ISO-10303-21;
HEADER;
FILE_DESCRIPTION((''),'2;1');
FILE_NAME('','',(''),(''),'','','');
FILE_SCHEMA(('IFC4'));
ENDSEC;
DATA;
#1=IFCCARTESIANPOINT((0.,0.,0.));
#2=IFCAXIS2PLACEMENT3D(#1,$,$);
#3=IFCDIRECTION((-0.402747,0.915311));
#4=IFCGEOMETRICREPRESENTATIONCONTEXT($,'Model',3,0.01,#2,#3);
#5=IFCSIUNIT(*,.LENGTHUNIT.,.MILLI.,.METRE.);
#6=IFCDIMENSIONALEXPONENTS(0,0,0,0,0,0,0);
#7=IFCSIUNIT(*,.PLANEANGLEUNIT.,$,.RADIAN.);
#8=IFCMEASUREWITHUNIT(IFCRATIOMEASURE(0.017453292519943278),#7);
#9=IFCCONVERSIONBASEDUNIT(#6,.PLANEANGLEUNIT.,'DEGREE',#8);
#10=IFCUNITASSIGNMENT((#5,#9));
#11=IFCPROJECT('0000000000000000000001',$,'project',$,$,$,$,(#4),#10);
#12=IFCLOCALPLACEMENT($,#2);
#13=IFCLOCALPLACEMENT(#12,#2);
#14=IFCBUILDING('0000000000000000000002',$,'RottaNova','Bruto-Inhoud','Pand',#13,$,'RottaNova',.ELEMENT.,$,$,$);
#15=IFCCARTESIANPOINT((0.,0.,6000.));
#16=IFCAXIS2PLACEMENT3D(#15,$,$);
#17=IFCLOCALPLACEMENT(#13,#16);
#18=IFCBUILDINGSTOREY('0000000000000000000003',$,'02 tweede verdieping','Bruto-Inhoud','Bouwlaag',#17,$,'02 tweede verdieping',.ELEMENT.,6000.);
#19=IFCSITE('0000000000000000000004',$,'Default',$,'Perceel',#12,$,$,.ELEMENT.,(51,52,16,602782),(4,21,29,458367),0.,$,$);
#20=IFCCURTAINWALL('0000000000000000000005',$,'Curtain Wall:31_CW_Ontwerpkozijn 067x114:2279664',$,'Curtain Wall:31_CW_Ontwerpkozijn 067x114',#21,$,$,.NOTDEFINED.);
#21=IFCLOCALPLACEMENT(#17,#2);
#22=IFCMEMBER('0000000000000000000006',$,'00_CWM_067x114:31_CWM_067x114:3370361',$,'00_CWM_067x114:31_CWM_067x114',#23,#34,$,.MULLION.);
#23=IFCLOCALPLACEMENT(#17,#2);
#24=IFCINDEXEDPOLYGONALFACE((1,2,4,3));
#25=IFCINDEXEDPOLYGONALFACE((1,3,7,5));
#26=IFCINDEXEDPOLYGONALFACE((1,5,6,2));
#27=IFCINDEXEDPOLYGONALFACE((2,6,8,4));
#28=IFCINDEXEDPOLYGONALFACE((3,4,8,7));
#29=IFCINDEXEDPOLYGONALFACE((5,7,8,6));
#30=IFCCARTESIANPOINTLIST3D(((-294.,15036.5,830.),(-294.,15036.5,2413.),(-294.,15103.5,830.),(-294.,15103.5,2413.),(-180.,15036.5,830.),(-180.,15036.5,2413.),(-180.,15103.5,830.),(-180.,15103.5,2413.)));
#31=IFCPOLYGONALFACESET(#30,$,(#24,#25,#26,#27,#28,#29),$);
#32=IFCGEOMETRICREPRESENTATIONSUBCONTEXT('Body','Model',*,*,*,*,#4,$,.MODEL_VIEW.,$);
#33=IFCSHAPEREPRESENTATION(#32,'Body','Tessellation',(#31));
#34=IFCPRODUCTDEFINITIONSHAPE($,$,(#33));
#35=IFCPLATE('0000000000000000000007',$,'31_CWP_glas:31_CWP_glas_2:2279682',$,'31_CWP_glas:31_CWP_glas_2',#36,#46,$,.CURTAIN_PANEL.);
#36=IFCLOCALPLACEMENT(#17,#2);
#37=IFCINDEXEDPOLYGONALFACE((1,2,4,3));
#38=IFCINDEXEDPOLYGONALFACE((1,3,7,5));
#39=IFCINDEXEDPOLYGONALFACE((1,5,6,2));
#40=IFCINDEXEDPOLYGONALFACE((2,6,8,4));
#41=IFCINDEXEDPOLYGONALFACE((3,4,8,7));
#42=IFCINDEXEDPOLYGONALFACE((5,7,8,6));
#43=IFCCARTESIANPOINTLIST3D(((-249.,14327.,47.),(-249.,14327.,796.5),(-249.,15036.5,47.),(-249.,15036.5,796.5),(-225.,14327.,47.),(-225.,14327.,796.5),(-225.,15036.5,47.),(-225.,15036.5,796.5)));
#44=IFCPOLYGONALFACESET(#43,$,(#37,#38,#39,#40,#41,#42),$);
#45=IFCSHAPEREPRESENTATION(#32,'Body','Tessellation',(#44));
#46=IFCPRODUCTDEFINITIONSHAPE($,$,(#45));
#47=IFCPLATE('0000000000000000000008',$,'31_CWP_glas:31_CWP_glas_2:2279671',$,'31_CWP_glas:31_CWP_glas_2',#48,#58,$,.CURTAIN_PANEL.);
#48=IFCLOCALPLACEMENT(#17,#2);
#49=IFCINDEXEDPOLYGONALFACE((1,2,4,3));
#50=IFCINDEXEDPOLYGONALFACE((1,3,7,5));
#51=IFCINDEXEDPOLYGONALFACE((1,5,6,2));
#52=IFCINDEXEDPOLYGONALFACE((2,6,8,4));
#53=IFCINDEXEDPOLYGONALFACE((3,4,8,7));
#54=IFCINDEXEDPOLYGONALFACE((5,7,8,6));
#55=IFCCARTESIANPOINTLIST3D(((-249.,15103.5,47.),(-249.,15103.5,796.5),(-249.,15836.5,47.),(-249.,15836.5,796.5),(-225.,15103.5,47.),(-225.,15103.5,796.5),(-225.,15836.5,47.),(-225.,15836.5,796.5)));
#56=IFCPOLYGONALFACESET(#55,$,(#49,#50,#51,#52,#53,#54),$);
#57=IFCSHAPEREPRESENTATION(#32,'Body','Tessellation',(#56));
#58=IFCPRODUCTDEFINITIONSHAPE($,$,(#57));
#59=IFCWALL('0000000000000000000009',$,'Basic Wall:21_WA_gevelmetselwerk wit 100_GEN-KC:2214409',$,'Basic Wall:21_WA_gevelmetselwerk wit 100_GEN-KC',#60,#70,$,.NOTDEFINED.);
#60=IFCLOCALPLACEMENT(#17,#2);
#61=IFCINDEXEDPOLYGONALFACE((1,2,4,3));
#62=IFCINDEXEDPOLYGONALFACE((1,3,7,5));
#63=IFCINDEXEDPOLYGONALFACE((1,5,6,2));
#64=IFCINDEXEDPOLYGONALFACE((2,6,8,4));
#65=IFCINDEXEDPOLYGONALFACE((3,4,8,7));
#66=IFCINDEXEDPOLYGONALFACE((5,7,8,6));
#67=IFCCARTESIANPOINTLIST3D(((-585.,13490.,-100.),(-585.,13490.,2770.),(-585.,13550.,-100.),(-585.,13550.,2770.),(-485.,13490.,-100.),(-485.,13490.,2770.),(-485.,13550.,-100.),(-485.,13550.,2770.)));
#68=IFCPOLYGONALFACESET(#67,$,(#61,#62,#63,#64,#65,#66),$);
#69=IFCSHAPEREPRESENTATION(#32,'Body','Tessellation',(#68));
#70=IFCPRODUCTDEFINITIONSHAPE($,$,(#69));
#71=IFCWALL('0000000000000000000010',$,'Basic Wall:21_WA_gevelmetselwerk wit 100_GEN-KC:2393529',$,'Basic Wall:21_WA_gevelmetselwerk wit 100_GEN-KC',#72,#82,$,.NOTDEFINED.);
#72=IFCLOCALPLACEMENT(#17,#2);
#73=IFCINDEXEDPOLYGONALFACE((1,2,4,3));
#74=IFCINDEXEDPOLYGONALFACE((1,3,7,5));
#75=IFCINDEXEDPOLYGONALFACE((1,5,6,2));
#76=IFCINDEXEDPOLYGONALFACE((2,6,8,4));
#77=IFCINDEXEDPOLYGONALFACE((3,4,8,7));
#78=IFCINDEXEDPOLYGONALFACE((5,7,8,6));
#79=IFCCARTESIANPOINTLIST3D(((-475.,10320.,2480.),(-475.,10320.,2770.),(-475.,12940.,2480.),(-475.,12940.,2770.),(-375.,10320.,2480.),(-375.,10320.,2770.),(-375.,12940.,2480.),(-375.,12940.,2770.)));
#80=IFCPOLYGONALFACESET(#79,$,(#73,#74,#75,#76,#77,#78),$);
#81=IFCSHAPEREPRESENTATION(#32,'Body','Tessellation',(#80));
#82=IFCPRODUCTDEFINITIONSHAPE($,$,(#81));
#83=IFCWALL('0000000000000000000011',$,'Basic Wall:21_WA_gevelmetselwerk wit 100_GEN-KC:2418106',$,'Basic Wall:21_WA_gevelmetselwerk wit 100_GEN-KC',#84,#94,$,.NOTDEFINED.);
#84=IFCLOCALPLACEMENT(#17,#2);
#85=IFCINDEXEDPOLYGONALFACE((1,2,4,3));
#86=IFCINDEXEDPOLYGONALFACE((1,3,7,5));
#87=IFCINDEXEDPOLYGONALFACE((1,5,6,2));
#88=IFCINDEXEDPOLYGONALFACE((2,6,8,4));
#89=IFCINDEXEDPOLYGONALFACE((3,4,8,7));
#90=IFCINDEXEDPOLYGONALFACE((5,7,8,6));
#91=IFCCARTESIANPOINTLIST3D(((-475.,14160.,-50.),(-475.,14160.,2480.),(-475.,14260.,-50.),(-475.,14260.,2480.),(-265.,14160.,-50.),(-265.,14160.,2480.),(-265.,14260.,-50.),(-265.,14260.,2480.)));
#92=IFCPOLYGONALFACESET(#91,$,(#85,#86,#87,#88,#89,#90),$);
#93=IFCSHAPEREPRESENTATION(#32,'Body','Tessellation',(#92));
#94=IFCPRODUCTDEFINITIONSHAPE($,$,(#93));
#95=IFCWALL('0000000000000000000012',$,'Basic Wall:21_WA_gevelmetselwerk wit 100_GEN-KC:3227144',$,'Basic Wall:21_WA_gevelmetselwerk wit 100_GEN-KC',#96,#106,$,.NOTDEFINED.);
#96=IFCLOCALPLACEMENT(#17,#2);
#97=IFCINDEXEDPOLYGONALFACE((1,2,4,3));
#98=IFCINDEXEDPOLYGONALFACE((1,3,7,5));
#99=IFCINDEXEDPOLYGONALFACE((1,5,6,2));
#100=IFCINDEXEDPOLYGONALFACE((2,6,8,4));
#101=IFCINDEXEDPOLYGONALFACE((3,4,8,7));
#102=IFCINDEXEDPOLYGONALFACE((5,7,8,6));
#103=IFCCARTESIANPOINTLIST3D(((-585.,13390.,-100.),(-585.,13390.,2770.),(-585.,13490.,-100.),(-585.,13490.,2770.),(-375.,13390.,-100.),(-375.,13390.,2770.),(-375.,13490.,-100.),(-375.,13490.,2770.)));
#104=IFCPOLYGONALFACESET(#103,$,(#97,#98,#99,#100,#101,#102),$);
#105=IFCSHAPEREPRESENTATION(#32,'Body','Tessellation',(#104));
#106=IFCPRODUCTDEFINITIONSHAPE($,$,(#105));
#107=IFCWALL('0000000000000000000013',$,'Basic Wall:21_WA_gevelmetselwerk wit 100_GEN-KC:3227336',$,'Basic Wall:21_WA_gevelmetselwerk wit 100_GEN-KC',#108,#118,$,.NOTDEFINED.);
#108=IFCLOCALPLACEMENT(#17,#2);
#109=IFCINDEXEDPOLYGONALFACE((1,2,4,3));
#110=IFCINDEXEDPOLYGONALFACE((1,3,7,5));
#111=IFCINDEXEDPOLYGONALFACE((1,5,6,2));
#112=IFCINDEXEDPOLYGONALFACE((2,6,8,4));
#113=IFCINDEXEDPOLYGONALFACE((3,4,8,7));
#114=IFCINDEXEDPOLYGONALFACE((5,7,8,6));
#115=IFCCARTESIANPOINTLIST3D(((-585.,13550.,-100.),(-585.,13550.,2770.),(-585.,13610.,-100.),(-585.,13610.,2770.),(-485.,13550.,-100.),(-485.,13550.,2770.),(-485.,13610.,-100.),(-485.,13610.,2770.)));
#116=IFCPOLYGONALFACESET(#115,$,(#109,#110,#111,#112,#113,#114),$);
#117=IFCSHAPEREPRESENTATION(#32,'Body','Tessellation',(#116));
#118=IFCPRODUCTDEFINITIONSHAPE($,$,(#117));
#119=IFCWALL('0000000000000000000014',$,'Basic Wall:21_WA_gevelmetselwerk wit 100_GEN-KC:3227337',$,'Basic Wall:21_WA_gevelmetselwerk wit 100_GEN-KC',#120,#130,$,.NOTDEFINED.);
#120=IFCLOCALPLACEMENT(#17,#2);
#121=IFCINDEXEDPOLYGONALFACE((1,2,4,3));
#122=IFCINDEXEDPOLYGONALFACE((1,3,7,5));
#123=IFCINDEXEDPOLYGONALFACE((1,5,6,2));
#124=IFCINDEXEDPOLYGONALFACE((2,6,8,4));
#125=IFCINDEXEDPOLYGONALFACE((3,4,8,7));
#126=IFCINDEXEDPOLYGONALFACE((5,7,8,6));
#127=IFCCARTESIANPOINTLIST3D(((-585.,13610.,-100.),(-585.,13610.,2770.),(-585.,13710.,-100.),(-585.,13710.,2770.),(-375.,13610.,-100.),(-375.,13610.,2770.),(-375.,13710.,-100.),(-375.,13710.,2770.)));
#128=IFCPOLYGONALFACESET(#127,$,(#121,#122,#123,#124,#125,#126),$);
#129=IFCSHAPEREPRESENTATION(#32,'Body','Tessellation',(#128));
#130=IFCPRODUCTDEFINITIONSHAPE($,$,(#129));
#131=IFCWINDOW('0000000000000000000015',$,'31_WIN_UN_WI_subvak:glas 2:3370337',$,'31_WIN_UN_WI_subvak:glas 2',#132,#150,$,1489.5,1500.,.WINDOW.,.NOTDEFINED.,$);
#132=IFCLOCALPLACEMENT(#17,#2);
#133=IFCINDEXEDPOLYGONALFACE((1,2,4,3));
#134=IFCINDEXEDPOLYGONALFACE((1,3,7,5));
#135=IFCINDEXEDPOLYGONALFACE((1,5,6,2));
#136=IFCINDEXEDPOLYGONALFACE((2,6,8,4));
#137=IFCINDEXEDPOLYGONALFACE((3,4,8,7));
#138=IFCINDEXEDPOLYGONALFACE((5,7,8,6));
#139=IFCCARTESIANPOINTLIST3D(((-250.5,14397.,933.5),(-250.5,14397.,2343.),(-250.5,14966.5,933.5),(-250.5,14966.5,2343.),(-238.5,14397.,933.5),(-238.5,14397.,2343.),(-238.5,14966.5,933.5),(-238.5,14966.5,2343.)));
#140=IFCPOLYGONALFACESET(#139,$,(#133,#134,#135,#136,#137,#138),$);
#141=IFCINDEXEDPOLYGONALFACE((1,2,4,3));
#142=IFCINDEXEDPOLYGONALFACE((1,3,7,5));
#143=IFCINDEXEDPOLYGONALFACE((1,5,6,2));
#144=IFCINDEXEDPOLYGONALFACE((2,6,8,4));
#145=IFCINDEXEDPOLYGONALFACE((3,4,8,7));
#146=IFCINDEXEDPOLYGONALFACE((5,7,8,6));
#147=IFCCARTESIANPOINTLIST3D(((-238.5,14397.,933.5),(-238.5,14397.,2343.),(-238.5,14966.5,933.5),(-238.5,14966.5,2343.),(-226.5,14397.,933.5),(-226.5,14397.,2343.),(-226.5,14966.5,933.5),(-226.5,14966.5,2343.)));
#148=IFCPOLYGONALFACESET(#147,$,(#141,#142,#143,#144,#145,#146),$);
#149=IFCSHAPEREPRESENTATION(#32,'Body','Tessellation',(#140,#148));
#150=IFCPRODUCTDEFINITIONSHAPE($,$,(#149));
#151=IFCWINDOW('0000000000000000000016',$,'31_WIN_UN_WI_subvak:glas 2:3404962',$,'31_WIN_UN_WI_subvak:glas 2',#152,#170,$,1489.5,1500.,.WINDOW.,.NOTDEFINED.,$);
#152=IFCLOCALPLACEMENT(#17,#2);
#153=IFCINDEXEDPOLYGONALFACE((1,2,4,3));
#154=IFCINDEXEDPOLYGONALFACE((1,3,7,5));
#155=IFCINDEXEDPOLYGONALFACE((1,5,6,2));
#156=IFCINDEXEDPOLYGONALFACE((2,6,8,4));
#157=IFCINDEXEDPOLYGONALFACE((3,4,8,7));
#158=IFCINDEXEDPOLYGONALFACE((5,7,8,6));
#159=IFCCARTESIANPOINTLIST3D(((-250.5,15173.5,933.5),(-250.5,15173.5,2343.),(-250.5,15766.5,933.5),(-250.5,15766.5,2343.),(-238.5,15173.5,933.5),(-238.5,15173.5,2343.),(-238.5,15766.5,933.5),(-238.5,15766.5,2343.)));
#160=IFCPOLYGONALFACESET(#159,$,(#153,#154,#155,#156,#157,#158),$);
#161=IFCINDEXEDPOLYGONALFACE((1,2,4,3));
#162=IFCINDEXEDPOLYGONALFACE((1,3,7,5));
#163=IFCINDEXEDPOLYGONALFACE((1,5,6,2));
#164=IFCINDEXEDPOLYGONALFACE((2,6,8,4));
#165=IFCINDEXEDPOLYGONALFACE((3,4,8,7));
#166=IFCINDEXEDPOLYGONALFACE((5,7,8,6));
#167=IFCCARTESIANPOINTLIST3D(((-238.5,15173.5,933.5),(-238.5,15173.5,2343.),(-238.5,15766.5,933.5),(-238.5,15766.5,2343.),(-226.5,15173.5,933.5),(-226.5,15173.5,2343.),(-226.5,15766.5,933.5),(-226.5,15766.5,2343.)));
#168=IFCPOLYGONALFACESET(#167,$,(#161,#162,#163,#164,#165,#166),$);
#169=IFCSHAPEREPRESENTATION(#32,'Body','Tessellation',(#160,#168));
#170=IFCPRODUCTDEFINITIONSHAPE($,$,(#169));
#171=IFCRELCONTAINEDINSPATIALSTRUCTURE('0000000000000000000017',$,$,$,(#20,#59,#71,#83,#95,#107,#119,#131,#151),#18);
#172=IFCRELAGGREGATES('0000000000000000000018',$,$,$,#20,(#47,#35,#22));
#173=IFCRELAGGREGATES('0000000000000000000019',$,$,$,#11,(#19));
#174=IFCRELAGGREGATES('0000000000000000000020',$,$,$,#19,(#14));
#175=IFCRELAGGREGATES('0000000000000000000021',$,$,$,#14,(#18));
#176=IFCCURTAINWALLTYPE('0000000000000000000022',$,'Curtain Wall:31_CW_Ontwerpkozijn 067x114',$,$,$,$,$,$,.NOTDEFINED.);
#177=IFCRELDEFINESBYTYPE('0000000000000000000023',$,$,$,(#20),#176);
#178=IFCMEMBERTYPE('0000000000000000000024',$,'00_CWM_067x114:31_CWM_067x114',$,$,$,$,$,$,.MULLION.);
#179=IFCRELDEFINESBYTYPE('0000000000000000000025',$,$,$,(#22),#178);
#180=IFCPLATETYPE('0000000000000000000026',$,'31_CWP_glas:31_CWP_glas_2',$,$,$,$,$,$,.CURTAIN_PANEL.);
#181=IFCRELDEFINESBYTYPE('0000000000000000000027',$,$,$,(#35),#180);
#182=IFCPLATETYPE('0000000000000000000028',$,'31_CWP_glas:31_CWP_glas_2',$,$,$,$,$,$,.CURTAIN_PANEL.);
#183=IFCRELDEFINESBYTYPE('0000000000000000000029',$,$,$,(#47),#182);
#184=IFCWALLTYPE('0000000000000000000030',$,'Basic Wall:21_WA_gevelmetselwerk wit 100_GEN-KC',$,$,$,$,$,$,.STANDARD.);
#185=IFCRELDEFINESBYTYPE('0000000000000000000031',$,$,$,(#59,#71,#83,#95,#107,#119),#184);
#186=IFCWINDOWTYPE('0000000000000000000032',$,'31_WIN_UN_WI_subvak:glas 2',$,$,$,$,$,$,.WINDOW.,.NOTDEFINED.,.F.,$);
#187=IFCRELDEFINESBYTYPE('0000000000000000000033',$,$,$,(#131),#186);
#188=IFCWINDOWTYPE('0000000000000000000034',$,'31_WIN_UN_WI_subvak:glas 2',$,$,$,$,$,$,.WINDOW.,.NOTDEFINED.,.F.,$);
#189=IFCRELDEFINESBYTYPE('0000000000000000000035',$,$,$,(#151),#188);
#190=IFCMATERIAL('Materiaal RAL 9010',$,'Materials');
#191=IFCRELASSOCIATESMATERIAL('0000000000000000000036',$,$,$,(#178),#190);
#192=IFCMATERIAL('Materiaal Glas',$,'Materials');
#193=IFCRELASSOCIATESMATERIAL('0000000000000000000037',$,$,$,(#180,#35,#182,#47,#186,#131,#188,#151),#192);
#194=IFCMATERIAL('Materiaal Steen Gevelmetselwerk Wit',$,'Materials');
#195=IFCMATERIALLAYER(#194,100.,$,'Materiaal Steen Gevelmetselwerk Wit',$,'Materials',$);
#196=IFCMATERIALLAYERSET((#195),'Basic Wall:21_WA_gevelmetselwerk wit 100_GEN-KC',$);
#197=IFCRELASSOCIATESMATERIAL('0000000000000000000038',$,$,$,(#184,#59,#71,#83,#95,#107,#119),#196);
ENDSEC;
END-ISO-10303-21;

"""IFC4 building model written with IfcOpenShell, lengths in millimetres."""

from ifc_helpers import new_model, entity, si_unit, converted_unit, direction, frame, frame_2d, origin, origin_2d_with_axis, place, context, subcontext, project, spatial, polyline, rectangle, extrude, clip, bounded_halfspace, source, transform, mapped, material, layer, layer_set, material_profile, profile_set, type_object, type_shapes, element, aggregate, save


model = new_model("IFC4")

# Units and contexts
model_context = context("Model", 3, precision=0.01, world=origin(), true_north=direction((-0.402747, 0.915311)))
body_context = subcontext(model_context, "Body", "Model", "MODEL_VIEW")
ifc_project = project(units=[si_unit("LENGTHUNIT", "METRE", prefix="MILLI"), converted_unit("PLANEANGLEUNIT", "DEGREE", entity("IfcRatioMeasure", 0.017453292519943278), si_unit("PLANEANGLEUNIT", "RADIAN"), dimensions=[0, 0, 0, 0, 0, 0, 0])], contexts=[model_context])

# Site, building, storey
site_placement = place(None, origin())
site = spatial("IfcSite", under=ifc_project, at=site_placement, Name="Default", ObjectType="Perceel", CompositionType="ELEMENT", RefLatitude=(51, 52, 16, 602782), RefLongitude=(4, 21, 29, 458367), RefElevation=0.0)
building_placement = place(site_placement, origin())
building = spatial("IfcBuilding", under=site, at=building_placement, Name="RottaNova", Description="Bruto-Inhoud", ObjectType="Pand", LongName="RottaNova", CompositionType="ELEMENT")
storey_placement = place(building_placement, frame((0.0, 0.0, 6000.0)))
storey = spatial("IfcBuildingStorey", under=building, at=storey_placement, Name="02 tweede verdieping", Description="Bruto-Inhoud", ObjectType="Bouwlaag", LongName="02 tweede verdieping", CompositionType="ELEMENT", Elevation=6000.0)

# Curtain wall, member, plates
curtain_wall_type = type_object("IfcCurtainWallType", Name="Curtain Wall:31_CW_Ontwerpkozijn 067x114", PredefinedType="NOTDEFINED")
curtain_wall_placement = place(storey_placement, frame((0.0, 0.0, -6000.0)))
curtain_wall = element("IfcCurtainWall", 1, at=curtain_wall_placement, inside=storey, type_object=curtain_wall_type, Name="Curtain Wall:31_CW_Ontwerpkozijn 067x114:2279664", ObjectType="Curtain Wall:31_CW_Ontwerpkozijn 067x114", PredefinedType="NOTDEFINED")
ifc_material_1 = material(Name="Materiaal RAL 9010", Category="Materials")
ifc_material_profile = material_profile(ifc_material_1, rectangle(XDim=114.0, YDim=67.0, at=origin_2d_with_axis()), Name="31_CWM_067x114")
ifc_profile_set = profile_set([ifc_material_profile], Name="31_CWM_067x114")
member_type_1 = type_object("IfcMemberType", Name="00_CWM_067x114:31_CWM_067x114", PredefinedType="MULLION", material=ifc_profile_set)
shared_shape_1 = source(origin(), body_context, "Body", "SweptSolid", [
    extrude(rectangle(XDim=114.0, YDim=67.0, at=origin_2d_with_axis()), frame((0.0, 57.0, -1583.0), z_axis=(0.0, 0.0, 1.0), x_axis=(0.0, -1.0, 0.0)), (0.0, 0.0, 1.0), 1583.0),
])
type_shapes(member_type_1, [shared_shape_1])
member_1_placement = place(curtain_wall_placement, frame((-180.0, 15070.0, 6830.0), z_axis=(0.0, 0.0, -1.0), x_axis=(0.0, -1.0, 0.0)))
member_1 = element("IfcMember", 2, at=member_1_placement, type_object=member_type_1, Name="00_CWM_067x114:31_CWM_067x114:3370361", ObjectType="00_CWM_067x114:31_CWM_067x114", PredefinedType="MULLION", context=body_context, shape_type="MappedRepresentation", body=[
    mapped(shared_shape_1, transform((0.0, 0.0, 0.0), scale=1.0)),
])
ifc_material_2 = material(Name="Materiaal Glas", Category="Materials")
plate_type_1 = type_object("IfcPlateType", Name="31_CWP_glas:31_CWP_glas_2", PredefinedType="CURTAIN_PANEL", material=ifc_material_2)
shared_shape_2 = source(origin(), body_context, "Body", "SweptSolid", [
    extrude(rectangle(XDim=24.0, YDim=709.5, at=frame_2d((0.0, 0.0), x_axis=(1.0, 0.0))), frame((354.8, 12.0, 0.0), z_axis=(0.0, 0.0, 1.0), x_axis=(0.0, 1.0, 0.0)), (0.0, 0.0, 1.0), 749.5),
])
type_shapes(plate_type_1, [shared_shape_2])
plate_1_placement = place(curtain_wall_placement, frame((-249.0, 15036.5, 6047.0), z_axis=(0.0, 0.0, 1.0), x_axis=(0.0, -1.0, 0.0)))
plate_1 = element("IfcPlate", 3, at=plate_1_placement, type_object=plate_type_1, material=ifc_material_2, Name="31_CWP_glas:31_CWP_glas_2:2279682", ObjectType="31_CWP_glas:31_CWP_glas_2", PredefinedType="CURTAIN_PANEL", context=body_context, shape_type="MappedRepresentation", body=[
    mapped(shared_shape_2, transform((0.0, 0.0, 0.0), scale=1.0)),
])
plate_type_2 = type_object("IfcPlateType", Name="31_CWP_glas:31_CWP_glas_2", PredefinedType="CURTAIN_PANEL", material=ifc_material_2)
shared_shape_3 = source(origin(), body_context, "Body", "SweptSolid", [
    extrude(rectangle(XDim=24.0, YDim=733.0, at=frame_2d((0.0, 0.0), x_axis=(1.0, 0.0))), frame((366.5, 12.0, 0.0), z_axis=(0.0, 0.0, 1.0), x_axis=(0.0, 1.0, 0.0)), (0.0, 0.0, 1.0), 749.5),
])
type_shapes(plate_type_2, [shared_shape_3])
plate_2_placement = place(curtain_wall_placement, frame((-249.0, 15836.5, 6047.0), z_axis=(0.0, 0.0, 1.0), x_axis=(0.0, -1.0, 0.0)))
plate_2 = element("IfcPlate", 4, at=plate_2_placement, type_object=plate_type_2, material=ifc_material_2, Name="31_CWP_glas:31_CWP_glas_2:2279671", ObjectType="31_CWP_glas:31_CWP_glas_2", PredefinedType="CURTAIN_PANEL", context=body_context, shape_type="MappedRepresentation", body=[
    mapped(shared_shape_3, transform((0.0, 0.0, 0.0), scale=1.0)),
])

# Shared definitions
ifc_material_3 = material(Name="Materiaal Steen Gevelmetselwerk Wit", Category="Materials")
ifc_layer_1 = layer(ifc_material_3, 100.0, Name="Materiaal Steen Gevelmetselwerk Wit", Category="Materials")
ifc_layer_set_1 = layer_set([ifc_layer_1], Name="Basic Wall:21_WA_gevelmetselwerk wit 100_GEN-KC")
wall_type_1 = type_object("IfcWallType", Name="Basic Wall:21_WA_gevelmetselwerk wit 100_GEN-KC", PredefinedType="STANDARD", material=ifc_layer_set_1)

# Wall
wall_1_placement = place(storey_placement, frame((-535.0, 13550.0, -100.0), z_axis=(0.0, 0.0, 1.0), x_axis=(0.0, -1.0, 0.0)))
element("IfcWall", 5, at=wall_1_placement, inside=storey, type_object=wall_type_1, material=ifc_layer_set_1, Name="Basic Wall:21_WA_gevelmetselwerk wit 100_GEN-KC:2214409", ObjectType="Basic Wall:21_WA_gevelmetselwerk wit 100_GEN-KC", PredefinedType="NOTDEFINED", context=body_context, shape_type="SweptSolid", body=[
    extrude(rectangle(XDim=60.0, YDim=100.0, at=frame_2d((30.0, 0.0), x_axis=(-1.0, 0.0))), origin(), (0.0, 0.0, 1.0), 2870.0),
])

# Walls
wall_2_placement = place(storey_placement, frame((-425.0, 12940.0, 2480.0), z_axis=(0.0, 0.0, 1.0), x_axis=(0.0, -1.0, 0.0)))
element("IfcWall", 6, at=wall_2_placement, inside=storey, type_object=wall_type_1, material=ifc_layer_set_1, Name="Basic Wall:21_WA_gevelmetselwerk wit 100_GEN-KC:2393529", ObjectType="Basic Wall:21_WA_gevelmetselwerk wit 100_GEN-KC", PredefinedType="NOTDEFINED", context=body_context, shape_type="Clipping", body=[
    clip(extrude(rectangle(XDim=2620.0, YDim=100.0, at=frame_2d((1310.0, 0.0), x_axis=(-1.0, 0.0))), origin(), (0.0, 0.0, 1.0), 290.0), bounded_halfspace(frame((2620.0, -50.0, 290.0), z_axis=(1.0, 0.0, 0.0), x_axis=(0.0, 1.0, 0.0)), False, frame((2620.0, -50.0, 290.0), z_axis=(1.0, 0.0, 0.0), x_axis=(0.0, 1.0, 0.0)), polyline([(0.0, 0.0), (0.0, -88392.0), (30480.0, -88392.0), (30480.0, 0.0), (0.0, 0.0)]))),
])
wall_3_placement = place(storey_placement, frame((-265.0, 14210.0, -50.0), z_axis=(0.0, 0.0, 1.0), x_axis=(-1.0, 0.0, 0.0)))
element("IfcWall", 7, at=wall_3_placement, inside=storey, type_object=wall_type_1, material=ifc_layer_set_1, Name="Basic Wall:21_WA_gevelmetselwerk wit 100_GEN-KC:2418106", ObjectType="Basic Wall:21_WA_gevelmetselwerk wit 100_GEN-KC", PredefinedType="NOTDEFINED", context=body_context, shape_type="SweptSolid", body=[
    extrude(rectangle(XDim=210.0, YDim=100.0, at=frame_2d((105.0, 0.0), x_axis=(-1.0, 0.0))), origin(), (0.0, 0.0, 1.0), 2530.0),
])
wall_4_placement = place(storey_placement, frame((-585.0, 13440.0, -100.0)))
element("IfcWall", 8, at=wall_4_placement, inside=storey, type_object=wall_type_1, material=ifc_layer_set_1, Name="Basic Wall:21_WA_gevelmetselwerk wit 100_GEN-KC:3227144", ObjectType="Basic Wall:21_WA_gevelmetselwerk wit 100_GEN-KC", PredefinedType="NOTDEFINED", context=body_context, shape_type="SweptSolid", body=[
    extrude(rectangle(XDim=210.0, YDim=100.0, at=frame_2d((105.0, 0.0), x_axis=(-1.0, 0.0))), origin(), (0.0, 0.0, 1.0), 2870.0),
])
wall_5_placement = place(storey_placement, frame((-535.0, 13550.0, -100.0), z_axis=(0.0, 0.0, 1.0), x_axis=(0.0, 1.0, 0.0)))
element("IfcWall", 9, at=wall_5_placement, inside=storey, type_object=wall_type_1, material=ifc_layer_set_1, Name="Basic Wall:21_WA_gevelmetselwerk wit 100_GEN-KC:3227336", ObjectType="Basic Wall:21_WA_gevelmetselwerk wit 100_GEN-KC", PredefinedType="NOTDEFINED", context=body_context, shape_type="SweptSolid", body=[
    extrude(rectangle(XDim=60.0, YDim=100.0, at=frame_2d((30.0, 0.0), x_axis=(-1.0, 0.0))), origin(), (0.0, 0.0, 1.0), 2870.0),
])
wall_6_placement = place(storey_placement, frame((-585.0, 13660.0, -100.0)))
element("IfcWall", 10, at=wall_6_placement, inside=storey, type_object=wall_type_1, material=ifc_layer_set_1, Name="Basic Wall:21_WA_gevelmetselwerk wit 100_GEN-KC:3227337", ObjectType="Basic Wall:21_WA_gevelmetselwerk wit 100_GEN-KC", PredefinedType="NOTDEFINED", context=body_context, shape_type="SweptSolid", body=[
    extrude(rectangle(XDim=210.0, YDim=100.0, at=frame_2d((105.0, 0.0), x_axis=(-1.0, 0.0))), origin(), (0.0, 0.0, 1.0), 2870.0),
])

# Windows
window_type_1 = type_object("IfcWindowType", Name="31_WIN_UN_WI_subvak:glas 2", ParameterTakesPrecedence=False, PartitioningType="NOTDEFINED", PredefinedType="WINDOW", material=ifc_material_2)
shared_shape_4 = source(origin(), body_context, "Body", "SweptSolid", [
    extrude(rectangle(XDim=569.5, YDim=12.0, at=origin_2d_with_axis()), frame((0.0, -6.0, 0.0)), (0.0, 0.0, 1.0), 1409.5),
    extrude(rectangle(XDim=569.5, YDim=12.0, at=origin_2d_with_axis()), frame((0.0, 6.0, 0.0)), (0.0, 0.0, 1.0), 1409.5),
])
type_shapes(window_type_1, [shared_shape_4])
window_1_placement = place(storey_placement, frame((-238.5, 14681.8, 933.5), z_axis=(0.0, 0.0, 1.0), x_axis=(0.0, -1.0, 0.0)))
element("IfcWindow", 11, at=window_1_placement, inside=storey, type_object=window_type_1, material=ifc_material_2, Name="31_WIN_UN_WI_subvak:glas 2:3370337", ObjectType="31_WIN_UN_WI_subvak:glas 2", OverallHeight=1489.5, OverallWidth=1500.0, PartitioningType="NOTDEFINED", PredefinedType="WINDOW", context=body_context, shape_type="MappedRepresentation", body=[
    mapped(shared_shape_4, transform((0.0, 0.0, 0.0), scale=1.0)),
])
window_type_2 = type_object("IfcWindowType", Name="31_WIN_UN_WI_subvak:glas 2", ParameterTakesPrecedence=False, PartitioningType="NOTDEFINED", PredefinedType="WINDOW", material=ifc_material_2)
shared_shape_5 = source(origin(), body_context, "Body", "SweptSolid", [
    extrude(rectangle(XDim=593.0, YDim=12.0, at=origin_2d_with_axis()), frame((0.0, -6.0, 0.0)), (0.0, 0.0, 1.0), 1409.5),
    extrude(rectangle(XDim=593.0, YDim=12.0, at=origin_2d_with_axis()), frame((0.0, 6.0, 0.0)), (0.0, 0.0, 1.0), 1409.5),
])
type_shapes(window_type_2, [shared_shape_5])
window_2_placement = place(storey_placement, frame((-238.5, 15470.0, 933.5), z_axis=(0.0, 0.0, 1.0), x_axis=(0.0, -1.0, 0.0)))
element("IfcWindow", 12, at=window_2_placement, inside=storey, type_object=window_type_2, material=ifc_material_2, Name="31_WIN_UN_WI_subvak:glas 2:3404962", ObjectType="31_WIN_UN_WI_subvak:glas 2", OverallHeight=1489.5, OverallWidth=1500.0, PartitioningType="NOTDEFINED", PredefinedType="WINDOW", context=body_context, shape_type="MappedRepresentation", body=[
    mapped(shared_shape_5, transform((0.0, 0.0, 0.0), scale=1.0)),
])

aggregate(curtain_wall, [plate_2, plate_1, member_1])

save(model, "model.ifc")
